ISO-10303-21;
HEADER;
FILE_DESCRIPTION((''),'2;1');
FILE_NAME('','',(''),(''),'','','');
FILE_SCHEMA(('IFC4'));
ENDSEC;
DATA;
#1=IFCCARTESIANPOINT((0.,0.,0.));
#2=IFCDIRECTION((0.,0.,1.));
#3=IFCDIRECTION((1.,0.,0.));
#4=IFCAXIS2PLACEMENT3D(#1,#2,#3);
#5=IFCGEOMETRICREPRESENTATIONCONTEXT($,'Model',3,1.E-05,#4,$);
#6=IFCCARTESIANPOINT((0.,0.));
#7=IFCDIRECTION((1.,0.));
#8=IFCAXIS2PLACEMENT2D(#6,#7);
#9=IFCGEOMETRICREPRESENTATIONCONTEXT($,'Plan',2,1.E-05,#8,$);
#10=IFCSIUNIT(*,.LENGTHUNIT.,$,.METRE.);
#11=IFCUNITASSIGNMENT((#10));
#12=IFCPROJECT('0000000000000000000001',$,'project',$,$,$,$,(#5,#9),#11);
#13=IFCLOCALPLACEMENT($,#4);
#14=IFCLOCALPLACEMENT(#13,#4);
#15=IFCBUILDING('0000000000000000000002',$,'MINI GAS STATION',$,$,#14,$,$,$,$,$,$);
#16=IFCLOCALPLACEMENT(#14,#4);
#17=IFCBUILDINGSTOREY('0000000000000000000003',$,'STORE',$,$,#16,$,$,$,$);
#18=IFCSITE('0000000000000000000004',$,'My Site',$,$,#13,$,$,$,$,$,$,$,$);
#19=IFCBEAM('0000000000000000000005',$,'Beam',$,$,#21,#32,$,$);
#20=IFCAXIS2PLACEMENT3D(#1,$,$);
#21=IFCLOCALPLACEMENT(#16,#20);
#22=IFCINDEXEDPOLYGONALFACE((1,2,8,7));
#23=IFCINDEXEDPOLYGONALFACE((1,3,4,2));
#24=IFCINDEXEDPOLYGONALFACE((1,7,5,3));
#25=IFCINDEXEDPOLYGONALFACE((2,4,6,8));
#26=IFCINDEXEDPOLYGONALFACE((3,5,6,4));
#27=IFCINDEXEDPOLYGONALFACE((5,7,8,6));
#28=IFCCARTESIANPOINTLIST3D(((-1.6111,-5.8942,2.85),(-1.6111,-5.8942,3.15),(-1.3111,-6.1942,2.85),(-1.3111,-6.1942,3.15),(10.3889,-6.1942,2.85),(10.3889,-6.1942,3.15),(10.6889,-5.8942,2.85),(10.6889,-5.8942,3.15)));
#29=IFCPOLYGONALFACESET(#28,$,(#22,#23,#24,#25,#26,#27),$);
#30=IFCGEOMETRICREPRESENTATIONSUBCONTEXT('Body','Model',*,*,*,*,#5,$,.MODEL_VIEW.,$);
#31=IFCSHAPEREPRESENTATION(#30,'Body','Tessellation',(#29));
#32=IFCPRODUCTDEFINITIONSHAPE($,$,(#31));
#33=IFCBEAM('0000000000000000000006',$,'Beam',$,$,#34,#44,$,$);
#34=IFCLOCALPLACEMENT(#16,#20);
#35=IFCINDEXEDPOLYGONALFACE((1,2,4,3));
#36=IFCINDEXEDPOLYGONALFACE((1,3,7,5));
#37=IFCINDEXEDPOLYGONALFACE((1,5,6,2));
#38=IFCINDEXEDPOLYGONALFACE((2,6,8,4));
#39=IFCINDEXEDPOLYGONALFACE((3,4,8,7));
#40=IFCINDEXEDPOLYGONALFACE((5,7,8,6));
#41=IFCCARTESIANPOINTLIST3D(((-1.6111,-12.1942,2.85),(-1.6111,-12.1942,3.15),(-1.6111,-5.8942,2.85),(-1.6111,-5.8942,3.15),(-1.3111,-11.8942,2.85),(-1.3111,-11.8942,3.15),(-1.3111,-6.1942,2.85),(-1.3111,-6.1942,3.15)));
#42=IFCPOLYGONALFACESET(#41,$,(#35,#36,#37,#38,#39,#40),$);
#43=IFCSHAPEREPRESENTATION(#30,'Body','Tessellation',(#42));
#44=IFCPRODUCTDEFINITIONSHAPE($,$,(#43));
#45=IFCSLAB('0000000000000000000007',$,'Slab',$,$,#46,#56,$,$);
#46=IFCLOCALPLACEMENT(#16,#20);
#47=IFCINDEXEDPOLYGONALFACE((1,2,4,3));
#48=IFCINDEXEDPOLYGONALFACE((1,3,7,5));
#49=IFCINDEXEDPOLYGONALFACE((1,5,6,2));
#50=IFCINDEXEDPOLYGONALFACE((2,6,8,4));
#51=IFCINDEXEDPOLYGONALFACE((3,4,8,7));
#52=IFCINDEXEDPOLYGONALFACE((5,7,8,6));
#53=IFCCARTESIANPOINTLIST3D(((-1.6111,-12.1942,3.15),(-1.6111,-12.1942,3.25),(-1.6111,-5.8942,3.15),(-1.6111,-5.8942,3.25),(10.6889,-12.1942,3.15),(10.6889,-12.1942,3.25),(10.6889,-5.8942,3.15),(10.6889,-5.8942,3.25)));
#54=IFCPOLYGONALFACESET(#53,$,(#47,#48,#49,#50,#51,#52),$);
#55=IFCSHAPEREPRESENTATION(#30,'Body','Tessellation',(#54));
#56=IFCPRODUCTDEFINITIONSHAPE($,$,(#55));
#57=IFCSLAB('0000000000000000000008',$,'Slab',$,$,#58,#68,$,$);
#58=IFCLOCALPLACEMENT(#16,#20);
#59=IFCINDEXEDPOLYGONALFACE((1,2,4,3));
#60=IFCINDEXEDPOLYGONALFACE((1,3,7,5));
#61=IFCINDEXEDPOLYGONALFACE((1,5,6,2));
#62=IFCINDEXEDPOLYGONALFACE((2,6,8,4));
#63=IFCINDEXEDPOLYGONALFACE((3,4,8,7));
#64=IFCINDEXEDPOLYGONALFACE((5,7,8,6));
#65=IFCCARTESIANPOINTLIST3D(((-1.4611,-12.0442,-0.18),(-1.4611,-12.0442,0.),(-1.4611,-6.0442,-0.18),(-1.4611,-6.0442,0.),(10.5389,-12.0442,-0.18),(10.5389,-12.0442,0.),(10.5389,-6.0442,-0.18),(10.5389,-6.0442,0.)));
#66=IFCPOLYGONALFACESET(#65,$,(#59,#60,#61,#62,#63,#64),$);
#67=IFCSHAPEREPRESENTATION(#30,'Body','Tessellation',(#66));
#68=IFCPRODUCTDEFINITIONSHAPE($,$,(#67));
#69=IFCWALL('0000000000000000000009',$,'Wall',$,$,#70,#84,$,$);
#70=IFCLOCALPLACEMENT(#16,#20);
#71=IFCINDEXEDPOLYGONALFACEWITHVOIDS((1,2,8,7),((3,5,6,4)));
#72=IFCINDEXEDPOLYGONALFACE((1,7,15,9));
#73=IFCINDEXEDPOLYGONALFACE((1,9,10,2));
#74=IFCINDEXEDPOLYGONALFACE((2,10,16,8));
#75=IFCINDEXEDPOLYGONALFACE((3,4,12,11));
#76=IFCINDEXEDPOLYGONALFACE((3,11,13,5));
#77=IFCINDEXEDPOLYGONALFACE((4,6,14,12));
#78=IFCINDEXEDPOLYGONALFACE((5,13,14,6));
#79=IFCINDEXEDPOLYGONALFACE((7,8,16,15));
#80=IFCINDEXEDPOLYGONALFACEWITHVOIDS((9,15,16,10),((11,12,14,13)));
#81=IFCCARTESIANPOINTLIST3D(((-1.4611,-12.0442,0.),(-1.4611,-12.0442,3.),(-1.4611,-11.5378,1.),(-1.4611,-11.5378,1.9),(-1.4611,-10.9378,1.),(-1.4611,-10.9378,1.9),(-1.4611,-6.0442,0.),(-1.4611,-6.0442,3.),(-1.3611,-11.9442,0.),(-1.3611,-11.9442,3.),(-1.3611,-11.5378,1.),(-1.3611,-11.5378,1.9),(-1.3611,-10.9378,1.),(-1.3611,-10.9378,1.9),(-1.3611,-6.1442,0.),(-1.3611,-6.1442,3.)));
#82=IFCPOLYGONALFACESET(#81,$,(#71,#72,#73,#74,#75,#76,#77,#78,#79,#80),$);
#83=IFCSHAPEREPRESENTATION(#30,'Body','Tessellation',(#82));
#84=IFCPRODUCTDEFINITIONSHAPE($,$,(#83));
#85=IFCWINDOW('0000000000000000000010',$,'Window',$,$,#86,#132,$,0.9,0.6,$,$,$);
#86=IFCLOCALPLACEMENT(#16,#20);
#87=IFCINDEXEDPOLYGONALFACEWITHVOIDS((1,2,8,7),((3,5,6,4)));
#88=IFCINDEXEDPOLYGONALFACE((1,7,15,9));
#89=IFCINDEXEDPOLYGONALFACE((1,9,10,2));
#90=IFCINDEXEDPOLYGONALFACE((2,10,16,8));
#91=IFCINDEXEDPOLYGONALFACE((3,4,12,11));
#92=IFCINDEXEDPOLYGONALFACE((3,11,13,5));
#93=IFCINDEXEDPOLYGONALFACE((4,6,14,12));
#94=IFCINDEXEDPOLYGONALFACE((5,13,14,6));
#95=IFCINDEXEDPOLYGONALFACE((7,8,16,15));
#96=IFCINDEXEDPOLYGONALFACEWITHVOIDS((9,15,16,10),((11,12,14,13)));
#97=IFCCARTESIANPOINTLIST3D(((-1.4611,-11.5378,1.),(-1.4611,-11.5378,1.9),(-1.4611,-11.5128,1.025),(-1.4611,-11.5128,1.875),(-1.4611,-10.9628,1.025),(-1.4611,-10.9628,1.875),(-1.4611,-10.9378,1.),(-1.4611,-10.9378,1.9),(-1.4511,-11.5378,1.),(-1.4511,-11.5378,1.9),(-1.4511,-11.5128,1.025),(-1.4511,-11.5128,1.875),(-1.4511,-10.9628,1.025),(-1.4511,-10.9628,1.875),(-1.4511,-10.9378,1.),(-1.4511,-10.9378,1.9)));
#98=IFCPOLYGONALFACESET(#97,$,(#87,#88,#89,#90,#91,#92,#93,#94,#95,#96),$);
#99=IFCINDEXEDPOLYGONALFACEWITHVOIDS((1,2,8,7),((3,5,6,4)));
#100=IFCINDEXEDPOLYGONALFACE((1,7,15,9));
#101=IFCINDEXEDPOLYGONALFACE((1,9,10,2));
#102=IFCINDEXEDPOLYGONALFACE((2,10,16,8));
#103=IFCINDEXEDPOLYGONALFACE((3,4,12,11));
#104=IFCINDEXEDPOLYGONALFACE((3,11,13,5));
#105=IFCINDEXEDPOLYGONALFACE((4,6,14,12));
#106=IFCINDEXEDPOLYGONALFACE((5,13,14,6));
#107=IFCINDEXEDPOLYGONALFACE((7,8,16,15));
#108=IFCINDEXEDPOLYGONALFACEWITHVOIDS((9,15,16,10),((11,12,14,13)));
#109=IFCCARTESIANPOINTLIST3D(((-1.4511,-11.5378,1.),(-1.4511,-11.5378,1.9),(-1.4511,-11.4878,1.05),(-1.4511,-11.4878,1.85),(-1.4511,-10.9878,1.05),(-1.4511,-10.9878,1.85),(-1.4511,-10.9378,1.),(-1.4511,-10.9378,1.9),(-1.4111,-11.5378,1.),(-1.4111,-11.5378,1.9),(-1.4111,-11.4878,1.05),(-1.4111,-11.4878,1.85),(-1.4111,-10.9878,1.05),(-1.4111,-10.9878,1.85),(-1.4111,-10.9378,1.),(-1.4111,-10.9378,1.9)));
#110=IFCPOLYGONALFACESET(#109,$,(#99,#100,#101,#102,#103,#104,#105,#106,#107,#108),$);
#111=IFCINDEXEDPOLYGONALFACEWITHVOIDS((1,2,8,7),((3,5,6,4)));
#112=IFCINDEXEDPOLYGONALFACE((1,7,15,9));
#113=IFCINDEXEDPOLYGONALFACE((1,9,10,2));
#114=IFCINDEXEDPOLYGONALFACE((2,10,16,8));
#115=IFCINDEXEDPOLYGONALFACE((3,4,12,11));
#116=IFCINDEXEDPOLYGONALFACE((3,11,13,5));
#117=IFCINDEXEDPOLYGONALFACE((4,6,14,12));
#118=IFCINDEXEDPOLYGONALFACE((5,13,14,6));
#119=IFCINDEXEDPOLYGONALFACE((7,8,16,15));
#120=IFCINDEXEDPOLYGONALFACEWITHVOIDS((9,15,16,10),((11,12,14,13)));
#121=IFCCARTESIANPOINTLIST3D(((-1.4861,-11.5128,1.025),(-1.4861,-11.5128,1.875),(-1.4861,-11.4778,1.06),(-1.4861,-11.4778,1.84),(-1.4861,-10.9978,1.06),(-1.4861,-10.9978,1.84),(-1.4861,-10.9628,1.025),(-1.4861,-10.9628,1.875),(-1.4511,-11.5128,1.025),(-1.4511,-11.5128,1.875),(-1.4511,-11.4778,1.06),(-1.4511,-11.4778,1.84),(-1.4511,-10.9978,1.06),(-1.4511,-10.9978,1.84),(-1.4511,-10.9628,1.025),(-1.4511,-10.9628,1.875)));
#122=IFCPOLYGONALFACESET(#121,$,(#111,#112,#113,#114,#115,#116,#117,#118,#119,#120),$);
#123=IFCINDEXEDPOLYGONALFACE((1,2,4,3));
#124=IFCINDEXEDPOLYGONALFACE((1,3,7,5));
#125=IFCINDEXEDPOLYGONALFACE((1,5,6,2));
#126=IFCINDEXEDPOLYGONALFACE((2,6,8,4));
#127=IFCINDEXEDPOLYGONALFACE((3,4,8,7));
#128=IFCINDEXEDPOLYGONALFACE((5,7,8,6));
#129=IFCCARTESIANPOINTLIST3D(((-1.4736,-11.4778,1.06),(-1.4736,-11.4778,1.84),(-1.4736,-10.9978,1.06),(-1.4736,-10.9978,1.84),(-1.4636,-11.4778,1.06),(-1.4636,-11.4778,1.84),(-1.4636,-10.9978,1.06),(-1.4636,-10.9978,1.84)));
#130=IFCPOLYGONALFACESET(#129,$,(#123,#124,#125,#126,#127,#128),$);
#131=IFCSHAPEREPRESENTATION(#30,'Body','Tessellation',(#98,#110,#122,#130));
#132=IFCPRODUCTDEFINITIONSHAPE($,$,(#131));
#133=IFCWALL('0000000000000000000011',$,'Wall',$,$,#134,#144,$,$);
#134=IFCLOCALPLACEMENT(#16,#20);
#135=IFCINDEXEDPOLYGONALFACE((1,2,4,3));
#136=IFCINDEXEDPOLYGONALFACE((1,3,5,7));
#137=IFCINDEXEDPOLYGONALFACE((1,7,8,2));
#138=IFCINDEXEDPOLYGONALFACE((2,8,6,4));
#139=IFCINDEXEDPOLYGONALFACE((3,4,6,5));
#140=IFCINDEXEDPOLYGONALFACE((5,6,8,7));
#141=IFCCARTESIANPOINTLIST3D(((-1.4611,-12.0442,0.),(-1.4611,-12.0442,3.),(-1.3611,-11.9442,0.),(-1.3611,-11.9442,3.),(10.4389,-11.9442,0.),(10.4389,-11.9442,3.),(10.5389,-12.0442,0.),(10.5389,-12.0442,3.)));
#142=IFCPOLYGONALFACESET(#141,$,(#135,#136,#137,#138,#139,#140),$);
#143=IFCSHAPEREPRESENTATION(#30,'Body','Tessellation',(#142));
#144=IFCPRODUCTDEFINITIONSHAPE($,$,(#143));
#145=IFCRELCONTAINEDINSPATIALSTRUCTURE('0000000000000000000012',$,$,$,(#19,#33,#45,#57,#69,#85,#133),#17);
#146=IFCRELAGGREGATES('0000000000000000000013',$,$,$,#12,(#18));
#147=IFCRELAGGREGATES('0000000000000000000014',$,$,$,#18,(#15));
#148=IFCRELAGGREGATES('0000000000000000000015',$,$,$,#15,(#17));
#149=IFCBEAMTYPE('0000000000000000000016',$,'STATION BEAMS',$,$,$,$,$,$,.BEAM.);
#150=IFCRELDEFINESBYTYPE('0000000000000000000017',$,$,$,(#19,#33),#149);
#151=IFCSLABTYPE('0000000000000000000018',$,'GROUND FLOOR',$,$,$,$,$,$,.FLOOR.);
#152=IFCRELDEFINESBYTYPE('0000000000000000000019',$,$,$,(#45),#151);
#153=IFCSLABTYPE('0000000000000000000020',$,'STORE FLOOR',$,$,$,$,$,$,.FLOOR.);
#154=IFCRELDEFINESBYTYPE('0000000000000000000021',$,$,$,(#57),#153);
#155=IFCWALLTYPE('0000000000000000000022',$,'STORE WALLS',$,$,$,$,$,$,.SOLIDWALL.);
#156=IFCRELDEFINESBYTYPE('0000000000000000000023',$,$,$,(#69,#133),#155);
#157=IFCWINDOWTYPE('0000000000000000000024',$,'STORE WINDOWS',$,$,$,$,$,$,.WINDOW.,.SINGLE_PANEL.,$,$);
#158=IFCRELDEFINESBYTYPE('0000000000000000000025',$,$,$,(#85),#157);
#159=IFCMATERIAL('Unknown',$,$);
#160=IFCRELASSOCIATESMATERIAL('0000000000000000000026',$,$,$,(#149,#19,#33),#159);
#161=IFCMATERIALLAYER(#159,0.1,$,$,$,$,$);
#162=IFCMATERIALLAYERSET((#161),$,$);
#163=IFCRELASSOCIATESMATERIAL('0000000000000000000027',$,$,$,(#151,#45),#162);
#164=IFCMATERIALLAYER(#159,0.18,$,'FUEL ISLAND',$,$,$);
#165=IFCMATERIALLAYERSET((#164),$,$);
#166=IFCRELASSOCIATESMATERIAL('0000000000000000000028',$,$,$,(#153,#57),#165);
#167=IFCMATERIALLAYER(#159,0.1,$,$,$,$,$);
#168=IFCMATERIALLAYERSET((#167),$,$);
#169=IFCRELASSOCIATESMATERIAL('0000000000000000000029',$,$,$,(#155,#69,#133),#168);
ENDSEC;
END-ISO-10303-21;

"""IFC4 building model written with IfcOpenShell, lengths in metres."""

from ifc_helpers import new_model, entity, si_unit, frame, origin_with_axes, origin_2d_with_axis, place, context, subcontext, project, spatial, line, indexed_curve, rectangle, outline, extrude, clip, halfspace, shape, source, transform, mapped, material, layer, layer_set, layer_usage, material_profile, profile_set, profile_usage, type_object, type_shapes, element, fill, save


model = new_model("IFC4")

# Units and contexts
model_context = context("Model", 3, precision=1e-05, world=origin_with_axes())
plan_context = context("Plan", 2, precision=1e-05, world=origin_2d_with_axis())
body_context_1 = subcontext(model_context, "Body", "Model", "MODEL_VIEW")
body_context_2 = subcontext(plan_context, "Body", "Plan", "PLAN_VIEW")
ifc_project = project(units=[si_unit("LENGTHUNIT", "METRE")], contexts=[model_context, plan_context])

# Site, building, storey
site_placement = place(None, origin_with_axes())
site = spatial("IfcSite", under=ifc_project, at=site_placement, Name="My Site")
building_placement = place(site_placement, origin_with_axes())
building = spatial("IfcBuilding", under=site, at=building_placement, Name="MINI GAS STATION")
storey_placement = place(building_placement, origin_with_axes())
storey = spatial("IfcBuildingStorey", under=building, at=storey_placement, Name="STORE")

# Beams
ifc_material = material(Name="Unknown")
ifc_material_profile = material_profile(ifc_material, rectangle(XDim=0.3, YDim=0.3))
ifc_profile_set = profile_set([ifc_material_profile])
ifc_profile_usage_1 = profile_usage(ifc_profile_set, cardinal=5)
beam_type = type_object("IfcBeamType", Name="STATION BEAMS", PredefinedType="BEAM", material=ifc_profile_set)
beam_1_placement = place(storey_placement, frame((-1.6111, -6.0442, 3.0), z_axis=(1.0, 0.0, 0.0), x_axis=(0.0, 1.0, 0.0)))
element("IfcBeam", 1, at=beam_1_placement, inside=storey, type_object=beam_type, material=ifc_profile_usage_1, Name="Beam", context=body_context_1, shape_type="Clipping", body=[
    clip(clip(extrude(rectangle(XDim=0.3, YDim=0.3), origin_with_axes(), (0.0, 0.0, 1.0), 12.3), halfspace(frame((0.15, -3.0, 12.3), z_axis=(-0.707106, 0.0, 0.707108), x_axis=(0.0, 1.0, 0.0)), False)), halfspace(frame((0.15, -3.0, 0.0), z_axis=(-0.707107, 0.0, -0.707107), x_axis=(0.0, 1.0, 0.0)), False)),
])
ifc_profile_usage_2 = profile_usage(ifc_profile_set, cardinal=5)
beam_2_placement = place(storey_placement, frame((-1.4611, -12.1942, 3.0), z_axis=(0.0, 1.0, -0.000001), x_axis=(-1.0, 0.0, 0.0)))
element("IfcBeam", 2, at=beam_2_placement, inside=storey, type_object=beam_type, material=ifc_profile_usage_2, Name="Beam", context=body_context_1, shape_type="Clipping", body=[
    clip(clip(extrude(rectangle(XDim=0.3, YDim=0.3), origin_with_axes(), (0.0, 0.0, 1.0), 6.3), halfspace(frame((0.15, -3.0, 6.3), z_axis=(-0.707107, 0.0, 0.707107), x_axis=(0.000001, 1.0, 0.0)), False)), halfspace(frame((0.15, -3.0, 0.0), z_axis=(-0.707106, 0.0, -0.707107), x_axis=(0.0, 1.0, 0.0)), False)),
])

# Slabs
ifc_layer_1 = layer(ifc_material, 0.1)
ifc_layer_set_1 = layer_set([ifc_layer_1])
ifc_layer_usage_1 = layer_usage(ifc_layer_set_1, "AXIS3", "POSITIVE", -0.1)
slab_type_1 = type_object("IfcSlabType", Name="GROUND FLOOR", PredefinedType="FLOOR", material=ifc_layer_set_1)
slab_1_placement = place(storey_placement, frame((-1.6111, -5.8942, 3.25), z_axis=(0.0, 0.0, 1.0), x_axis=(1.0, 0.0, 0.0)))
element("IfcSlab", 3, at=slab_1_placement, inside=storey, type_object=slab_type_1, material=ifc_layer_usage_1, Name="Slab", context=body_context_1, shape_type="SweptSolid", body=[
    extrude(outline(indexed_curve([(0.0, 0.0), (12.3, 0.0), (12.3, -6.3), (0.0, -6.3), (0.0, 0.0)])), frame((0.0, 0.0, -0.1), z_axis=(0.0, 0.0, 1.0), x_axis=(1.0, 0.0, 0.0)), (0.0, 0.0, 1.0), 0.1),
])
ifc_layer_2 = layer(ifc_material, 0.18, Name="FUEL ISLAND")
ifc_layer_set_2 = layer_set([ifc_layer_2])
ifc_layer_usage_2 = layer_usage(ifc_layer_set_2, "AXIS3", "POSITIVE", -0.18)
slab_type_2 = type_object("IfcSlabType", Name="STORE FLOOR", PredefinedType="FLOOR", material=ifc_layer_set_2)
slab_2_placement = place(storey_placement, frame((-1.4611, -6.0442, 0.0), z_axis=(0.0, 0.0, 1.0), x_axis=(1.0, 0.0, 0.0)))
element("IfcSlab", 4, at=slab_2_placement, inside=storey, type_object=slab_type_2, material=ifc_layer_usage_2, Name="Slab", context=body_context_1, shape_type="SweptSolid", body=[
    extrude(outline(indexed_curve([(0.0, 0.0), (12.0, 0.0), (12.0, -6.0), (0.0, -6.0), (0.0, 0.0)])), frame((0.0, 0.0, -0.18), z_axis=(0.0, 0.0, 1.0), x_axis=(1.0, 0.0, 0.0)), (0.0, 0.0, 1.0), 0.18),
])

# Wall, opening, window
ifc_layer_3 = layer(ifc_material, 0.1)
ifc_layer_set_3 = layer_set([ifc_layer_3])
ifc_layer_usage_3 = layer_usage(ifc_layer_set_3, "AXIS2", "POSITIVE", 0.0)
wall_type_1 = type_object("IfcWallType", Name="STORE WALLS", PredefinedType="SOLIDWALL", material=ifc_layer_set_3)
wall_1_placement = place(storey_placement, frame((-1.3611, -12.0442, 0.0), z_axis=(0.0, 0.0, 1.0), x_axis=(0.0, 1.0, 0.0)))
wall_1 = element("IfcWall", 5, at=wall_1_placement, inside=storey, type_object=wall_type_1, material=ifc_layer_usage_3, Name="Wall", context=body_context_1, shape_type="SweptSolid", body=[
    extrude(outline(indexed_curve([(0.1, 0.0), (0.0, 0.1), (6.0, 0.1), (5.9, 0.0)], segments=[line(1, 2, 3, 4, 1)])), origin_with_axes(), (0.0, 0.0, 1.0), 3.0),
])
shared_shape_1 = source(origin_with_axes(), body_context_1, "Body", "SweptSolid", [
    extrude(outline(indexed_curve([(0.0, 0.0), (0.6, 0.0), (0.6, 0.9), (0.0, 0.9)], segments=[line(1, 2, 3, 4, 1)])), frame((0.0, -0.6, 0.0), z_axis=(0.0, -1.0, 0.0), x_axis=(1.0, 0.0, 0.0)), (0.0, 0.0, -1.0), 1.2),
])
opening_1_placement = place(wall_1_placement, frame((0.5065, 0.0, 1.0), z_axis=(0.0, 0.0, 1.0), x_axis=(1.0, 0.0, 0.0)))
opening_1 = element("IfcOpeningElement", 6, at=opening_1_placement, cuts=wall_1, PredefinedType="OPENING", context=body_context_1, shape_type="MappedRepresentation", body=[
    mapped(shared_shape_1, transform((0.0, 0.0, 0.0), x_axis=(1.0, 0.0, 0.0), y_axis=(0.0, 1.0, 0.0), z_axis=(0.0, 0.0, 1.0), scale=1.0)),
])
window_type = type_object("IfcWindowType", Name="STORE WINDOWS", PartitioningType="SINGLE_PANEL", PredefinedType="WINDOW")
shared_shape_2 = source(origin_with_axes(), body_context_1, "Body", "SweptSolid", [
    extrude(outline(indexed_curve([(0.0, 0.0), (0.6, 0.0), (0.6, 0.9), (0.0, 0.9)], segments=[line(1, 2, 3, 4, 1)]), holes=[indexed_curve([(0.025, 0.025), (0.575, 0.025), (0.575, 0.875), (0.025, 0.875)], segments=[line(1, 2, 3, 4, 1)])]), frame((0.0, 0.09, 0.0), z_axis=(0.0, -1.0, 0.0), x_axis=(1.0, 0.0, 0.0)), (0.0, 0.0, -1.0), 0.01),
    extrude(outline(indexed_curve([(0.0, 0.0), (0.6, 0.0), (0.6, 0.9), (0.0, 0.9)], segments=[line(1, 2, 3, 4, 1)]), holes=[indexed_curve([(0.05, 0.05), (0.55, 0.05), (0.55, 0.85), (0.05, 0.85)], segments=[line(1, 2, 3, 4, 1)])]), frame((0.0, 0.05, 0.0), z_axis=(0.0, -1.0, 0.0), x_axis=(1.0, 0.0, 0.0)), (0.0, 0.0, -1.0), 0.04),
    extrude(outline(indexed_curve([(0.0, 0.0), (0.55, 0.0), (0.55, 0.85), (0.0, 0.85)], segments=[line(1, 2, 3, 4, 1)]), holes=[indexed_curve([(0.035, 0.035), (0.515, 0.035), (0.515, 0.815), (0.035, 0.815)], segments=[line(1, 2, 3, 4, 1)])]), frame((0.025, 0.09, 0.025), z_axis=(0.0, -1.0, 0.0), x_axis=(1.0, 0.0, 0.0)), (0.0, 0.0, -1.0), 0.035),
    extrude(outline(indexed_curve([(0.035, 0.035), (0.515, 0.035), (0.515, 0.815), (0.035, 0.815)], segments=[line(1, 2, 3, 4, 1)])), frame((0.025, 0.1025, 0.025), z_axis=(0.0, -1.0, 0.0), x_axis=(1.0, 0.0, 0.0)), (0.0, 0.0, -1.0), 0.01),
])
shared_shape_3 = source(origin_with_axes(), body_context_2, "Body", "Curve2D", [
    entity("IfcIndexedPolyCurve", entity("IfcCartesianPointList2D", [[0.05, 0.05], [0.55, 0.05]])),
    entity("IfcIndexedPolyCurve", entity("IfcCartesianPointList2D", [[0.0, 0.1], [0.025, 0.1], [0.025, 0.09], [0.05, 0.09], [0.05, 0.05], [0.0, 0.05]]), [entity("IfcLineIndex", [1, 2, 3, 4, 5, 6, 1])]),
    entity("IfcIndexedPolyCurve", entity("IfcCartesianPointList2D", [[0.6, 0.1], [0.575, 0.1], [0.575, 0.09], [0.55, 0.09], [0.55, 0.05], [0.6, 0.05]]), [entity("IfcLineIndex", [1, 2, 3, 4, 5, 6, 1])]),
    entity("IfcIndexedPolyCurve", entity("IfcCartesianPointList2D", [[0.025, 0.09], [0.06, 0.09], [0.06, 0.125], [0.025, 0.125]]), [entity("IfcLineIndex", [1, 2, 3, 4, 1])]),
    entity("IfcIndexedPolyCurve", entity("IfcCartesianPointList2D", [[0.575, 0.09], [0.54, 0.09], [0.54, 0.125], [0.575, 0.125]]), [entity("IfcLineIndex", [1, 2, 3, 4, 1])]),
    entity("IfcIndexedPolyCurve", entity("IfcCartesianPointList2D", [[0.06, 0.09], [0.54, 0.09]])),
    entity("IfcIndexedPolyCurve", entity("IfcCartesianPointList2D", [[0.06, 0.125], [0.54, 0.125]])),
    entity("IfcIndexedPolyCurve", entity("IfcCartesianPointList2D", [[0.06, 0.1075], [0.54, 0.1075]])),
])
type_shapes(window_type, [shared_shape_2, shared_shape_3])
window_placement = place(opening_1_placement, frame((0.0, 0.0, 0.0), z_axis=(0.0, 0.0, 1.0), x_axis=(1.0, 0.0, 0.0)))
window = element("IfcWindow", 7, at=window_placement, inside=storey, type_object=window_type, Name="Window", OverallHeight=0.9, OverallWidth=0.6, shapes=[
    shape(body_context_1, "Body", "MappedRepresentation", [mapped(shared_shape_2, transform((0.0, 0.0, 0.0), x_axis=(1.0, 0.0, 0.0), y_axis=(0.0, 1.0, 0.0), z_axis=(0.0, 0.0, 1.0), scale=1.0))]),
    shape(body_context_2, "Body", "MappedRepresentation", [mapped(shared_shape_3, transform((0.0, 0.0, 0.0), x_axis=(1.0, 0.0, 0.0), y_axis=(0.0, 1.0, 0.0), z_axis=(0.0, 0.0, 1.0), scale=1.0))]),
])
fill(opening_1, window)

# Wall
ifc_layer_usage_4 = layer_usage(ifc_layer_set_3, "AXIS2", "POSITIVE", 0.0)
wall_2_placement = place(storey_placement, frame((-1.3611, -12.0442, 0.0), z_axis=(0.0, 0.0, 1.0), x_axis=(1.0, 0.0, 0.0)))
element("IfcWall", 8, at=wall_2_placement, inside=storey, type_object=wall_type_1, material=ifc_layer_usage_4, Name="Wall", context=body_context_1, shape_type="SweptSolid", body=[
    extrude(outline(indexed_curve([(-0.1, 0.0), (0.0, 0.1), (11.8, 0.1), (11.9, 0.0)], segments=[line(1, 2, 3, 4, 1)])), origin_with_axes(), (0.0, 0.0, 1.0), 3.0),
])

save(model, "model.ifc")
